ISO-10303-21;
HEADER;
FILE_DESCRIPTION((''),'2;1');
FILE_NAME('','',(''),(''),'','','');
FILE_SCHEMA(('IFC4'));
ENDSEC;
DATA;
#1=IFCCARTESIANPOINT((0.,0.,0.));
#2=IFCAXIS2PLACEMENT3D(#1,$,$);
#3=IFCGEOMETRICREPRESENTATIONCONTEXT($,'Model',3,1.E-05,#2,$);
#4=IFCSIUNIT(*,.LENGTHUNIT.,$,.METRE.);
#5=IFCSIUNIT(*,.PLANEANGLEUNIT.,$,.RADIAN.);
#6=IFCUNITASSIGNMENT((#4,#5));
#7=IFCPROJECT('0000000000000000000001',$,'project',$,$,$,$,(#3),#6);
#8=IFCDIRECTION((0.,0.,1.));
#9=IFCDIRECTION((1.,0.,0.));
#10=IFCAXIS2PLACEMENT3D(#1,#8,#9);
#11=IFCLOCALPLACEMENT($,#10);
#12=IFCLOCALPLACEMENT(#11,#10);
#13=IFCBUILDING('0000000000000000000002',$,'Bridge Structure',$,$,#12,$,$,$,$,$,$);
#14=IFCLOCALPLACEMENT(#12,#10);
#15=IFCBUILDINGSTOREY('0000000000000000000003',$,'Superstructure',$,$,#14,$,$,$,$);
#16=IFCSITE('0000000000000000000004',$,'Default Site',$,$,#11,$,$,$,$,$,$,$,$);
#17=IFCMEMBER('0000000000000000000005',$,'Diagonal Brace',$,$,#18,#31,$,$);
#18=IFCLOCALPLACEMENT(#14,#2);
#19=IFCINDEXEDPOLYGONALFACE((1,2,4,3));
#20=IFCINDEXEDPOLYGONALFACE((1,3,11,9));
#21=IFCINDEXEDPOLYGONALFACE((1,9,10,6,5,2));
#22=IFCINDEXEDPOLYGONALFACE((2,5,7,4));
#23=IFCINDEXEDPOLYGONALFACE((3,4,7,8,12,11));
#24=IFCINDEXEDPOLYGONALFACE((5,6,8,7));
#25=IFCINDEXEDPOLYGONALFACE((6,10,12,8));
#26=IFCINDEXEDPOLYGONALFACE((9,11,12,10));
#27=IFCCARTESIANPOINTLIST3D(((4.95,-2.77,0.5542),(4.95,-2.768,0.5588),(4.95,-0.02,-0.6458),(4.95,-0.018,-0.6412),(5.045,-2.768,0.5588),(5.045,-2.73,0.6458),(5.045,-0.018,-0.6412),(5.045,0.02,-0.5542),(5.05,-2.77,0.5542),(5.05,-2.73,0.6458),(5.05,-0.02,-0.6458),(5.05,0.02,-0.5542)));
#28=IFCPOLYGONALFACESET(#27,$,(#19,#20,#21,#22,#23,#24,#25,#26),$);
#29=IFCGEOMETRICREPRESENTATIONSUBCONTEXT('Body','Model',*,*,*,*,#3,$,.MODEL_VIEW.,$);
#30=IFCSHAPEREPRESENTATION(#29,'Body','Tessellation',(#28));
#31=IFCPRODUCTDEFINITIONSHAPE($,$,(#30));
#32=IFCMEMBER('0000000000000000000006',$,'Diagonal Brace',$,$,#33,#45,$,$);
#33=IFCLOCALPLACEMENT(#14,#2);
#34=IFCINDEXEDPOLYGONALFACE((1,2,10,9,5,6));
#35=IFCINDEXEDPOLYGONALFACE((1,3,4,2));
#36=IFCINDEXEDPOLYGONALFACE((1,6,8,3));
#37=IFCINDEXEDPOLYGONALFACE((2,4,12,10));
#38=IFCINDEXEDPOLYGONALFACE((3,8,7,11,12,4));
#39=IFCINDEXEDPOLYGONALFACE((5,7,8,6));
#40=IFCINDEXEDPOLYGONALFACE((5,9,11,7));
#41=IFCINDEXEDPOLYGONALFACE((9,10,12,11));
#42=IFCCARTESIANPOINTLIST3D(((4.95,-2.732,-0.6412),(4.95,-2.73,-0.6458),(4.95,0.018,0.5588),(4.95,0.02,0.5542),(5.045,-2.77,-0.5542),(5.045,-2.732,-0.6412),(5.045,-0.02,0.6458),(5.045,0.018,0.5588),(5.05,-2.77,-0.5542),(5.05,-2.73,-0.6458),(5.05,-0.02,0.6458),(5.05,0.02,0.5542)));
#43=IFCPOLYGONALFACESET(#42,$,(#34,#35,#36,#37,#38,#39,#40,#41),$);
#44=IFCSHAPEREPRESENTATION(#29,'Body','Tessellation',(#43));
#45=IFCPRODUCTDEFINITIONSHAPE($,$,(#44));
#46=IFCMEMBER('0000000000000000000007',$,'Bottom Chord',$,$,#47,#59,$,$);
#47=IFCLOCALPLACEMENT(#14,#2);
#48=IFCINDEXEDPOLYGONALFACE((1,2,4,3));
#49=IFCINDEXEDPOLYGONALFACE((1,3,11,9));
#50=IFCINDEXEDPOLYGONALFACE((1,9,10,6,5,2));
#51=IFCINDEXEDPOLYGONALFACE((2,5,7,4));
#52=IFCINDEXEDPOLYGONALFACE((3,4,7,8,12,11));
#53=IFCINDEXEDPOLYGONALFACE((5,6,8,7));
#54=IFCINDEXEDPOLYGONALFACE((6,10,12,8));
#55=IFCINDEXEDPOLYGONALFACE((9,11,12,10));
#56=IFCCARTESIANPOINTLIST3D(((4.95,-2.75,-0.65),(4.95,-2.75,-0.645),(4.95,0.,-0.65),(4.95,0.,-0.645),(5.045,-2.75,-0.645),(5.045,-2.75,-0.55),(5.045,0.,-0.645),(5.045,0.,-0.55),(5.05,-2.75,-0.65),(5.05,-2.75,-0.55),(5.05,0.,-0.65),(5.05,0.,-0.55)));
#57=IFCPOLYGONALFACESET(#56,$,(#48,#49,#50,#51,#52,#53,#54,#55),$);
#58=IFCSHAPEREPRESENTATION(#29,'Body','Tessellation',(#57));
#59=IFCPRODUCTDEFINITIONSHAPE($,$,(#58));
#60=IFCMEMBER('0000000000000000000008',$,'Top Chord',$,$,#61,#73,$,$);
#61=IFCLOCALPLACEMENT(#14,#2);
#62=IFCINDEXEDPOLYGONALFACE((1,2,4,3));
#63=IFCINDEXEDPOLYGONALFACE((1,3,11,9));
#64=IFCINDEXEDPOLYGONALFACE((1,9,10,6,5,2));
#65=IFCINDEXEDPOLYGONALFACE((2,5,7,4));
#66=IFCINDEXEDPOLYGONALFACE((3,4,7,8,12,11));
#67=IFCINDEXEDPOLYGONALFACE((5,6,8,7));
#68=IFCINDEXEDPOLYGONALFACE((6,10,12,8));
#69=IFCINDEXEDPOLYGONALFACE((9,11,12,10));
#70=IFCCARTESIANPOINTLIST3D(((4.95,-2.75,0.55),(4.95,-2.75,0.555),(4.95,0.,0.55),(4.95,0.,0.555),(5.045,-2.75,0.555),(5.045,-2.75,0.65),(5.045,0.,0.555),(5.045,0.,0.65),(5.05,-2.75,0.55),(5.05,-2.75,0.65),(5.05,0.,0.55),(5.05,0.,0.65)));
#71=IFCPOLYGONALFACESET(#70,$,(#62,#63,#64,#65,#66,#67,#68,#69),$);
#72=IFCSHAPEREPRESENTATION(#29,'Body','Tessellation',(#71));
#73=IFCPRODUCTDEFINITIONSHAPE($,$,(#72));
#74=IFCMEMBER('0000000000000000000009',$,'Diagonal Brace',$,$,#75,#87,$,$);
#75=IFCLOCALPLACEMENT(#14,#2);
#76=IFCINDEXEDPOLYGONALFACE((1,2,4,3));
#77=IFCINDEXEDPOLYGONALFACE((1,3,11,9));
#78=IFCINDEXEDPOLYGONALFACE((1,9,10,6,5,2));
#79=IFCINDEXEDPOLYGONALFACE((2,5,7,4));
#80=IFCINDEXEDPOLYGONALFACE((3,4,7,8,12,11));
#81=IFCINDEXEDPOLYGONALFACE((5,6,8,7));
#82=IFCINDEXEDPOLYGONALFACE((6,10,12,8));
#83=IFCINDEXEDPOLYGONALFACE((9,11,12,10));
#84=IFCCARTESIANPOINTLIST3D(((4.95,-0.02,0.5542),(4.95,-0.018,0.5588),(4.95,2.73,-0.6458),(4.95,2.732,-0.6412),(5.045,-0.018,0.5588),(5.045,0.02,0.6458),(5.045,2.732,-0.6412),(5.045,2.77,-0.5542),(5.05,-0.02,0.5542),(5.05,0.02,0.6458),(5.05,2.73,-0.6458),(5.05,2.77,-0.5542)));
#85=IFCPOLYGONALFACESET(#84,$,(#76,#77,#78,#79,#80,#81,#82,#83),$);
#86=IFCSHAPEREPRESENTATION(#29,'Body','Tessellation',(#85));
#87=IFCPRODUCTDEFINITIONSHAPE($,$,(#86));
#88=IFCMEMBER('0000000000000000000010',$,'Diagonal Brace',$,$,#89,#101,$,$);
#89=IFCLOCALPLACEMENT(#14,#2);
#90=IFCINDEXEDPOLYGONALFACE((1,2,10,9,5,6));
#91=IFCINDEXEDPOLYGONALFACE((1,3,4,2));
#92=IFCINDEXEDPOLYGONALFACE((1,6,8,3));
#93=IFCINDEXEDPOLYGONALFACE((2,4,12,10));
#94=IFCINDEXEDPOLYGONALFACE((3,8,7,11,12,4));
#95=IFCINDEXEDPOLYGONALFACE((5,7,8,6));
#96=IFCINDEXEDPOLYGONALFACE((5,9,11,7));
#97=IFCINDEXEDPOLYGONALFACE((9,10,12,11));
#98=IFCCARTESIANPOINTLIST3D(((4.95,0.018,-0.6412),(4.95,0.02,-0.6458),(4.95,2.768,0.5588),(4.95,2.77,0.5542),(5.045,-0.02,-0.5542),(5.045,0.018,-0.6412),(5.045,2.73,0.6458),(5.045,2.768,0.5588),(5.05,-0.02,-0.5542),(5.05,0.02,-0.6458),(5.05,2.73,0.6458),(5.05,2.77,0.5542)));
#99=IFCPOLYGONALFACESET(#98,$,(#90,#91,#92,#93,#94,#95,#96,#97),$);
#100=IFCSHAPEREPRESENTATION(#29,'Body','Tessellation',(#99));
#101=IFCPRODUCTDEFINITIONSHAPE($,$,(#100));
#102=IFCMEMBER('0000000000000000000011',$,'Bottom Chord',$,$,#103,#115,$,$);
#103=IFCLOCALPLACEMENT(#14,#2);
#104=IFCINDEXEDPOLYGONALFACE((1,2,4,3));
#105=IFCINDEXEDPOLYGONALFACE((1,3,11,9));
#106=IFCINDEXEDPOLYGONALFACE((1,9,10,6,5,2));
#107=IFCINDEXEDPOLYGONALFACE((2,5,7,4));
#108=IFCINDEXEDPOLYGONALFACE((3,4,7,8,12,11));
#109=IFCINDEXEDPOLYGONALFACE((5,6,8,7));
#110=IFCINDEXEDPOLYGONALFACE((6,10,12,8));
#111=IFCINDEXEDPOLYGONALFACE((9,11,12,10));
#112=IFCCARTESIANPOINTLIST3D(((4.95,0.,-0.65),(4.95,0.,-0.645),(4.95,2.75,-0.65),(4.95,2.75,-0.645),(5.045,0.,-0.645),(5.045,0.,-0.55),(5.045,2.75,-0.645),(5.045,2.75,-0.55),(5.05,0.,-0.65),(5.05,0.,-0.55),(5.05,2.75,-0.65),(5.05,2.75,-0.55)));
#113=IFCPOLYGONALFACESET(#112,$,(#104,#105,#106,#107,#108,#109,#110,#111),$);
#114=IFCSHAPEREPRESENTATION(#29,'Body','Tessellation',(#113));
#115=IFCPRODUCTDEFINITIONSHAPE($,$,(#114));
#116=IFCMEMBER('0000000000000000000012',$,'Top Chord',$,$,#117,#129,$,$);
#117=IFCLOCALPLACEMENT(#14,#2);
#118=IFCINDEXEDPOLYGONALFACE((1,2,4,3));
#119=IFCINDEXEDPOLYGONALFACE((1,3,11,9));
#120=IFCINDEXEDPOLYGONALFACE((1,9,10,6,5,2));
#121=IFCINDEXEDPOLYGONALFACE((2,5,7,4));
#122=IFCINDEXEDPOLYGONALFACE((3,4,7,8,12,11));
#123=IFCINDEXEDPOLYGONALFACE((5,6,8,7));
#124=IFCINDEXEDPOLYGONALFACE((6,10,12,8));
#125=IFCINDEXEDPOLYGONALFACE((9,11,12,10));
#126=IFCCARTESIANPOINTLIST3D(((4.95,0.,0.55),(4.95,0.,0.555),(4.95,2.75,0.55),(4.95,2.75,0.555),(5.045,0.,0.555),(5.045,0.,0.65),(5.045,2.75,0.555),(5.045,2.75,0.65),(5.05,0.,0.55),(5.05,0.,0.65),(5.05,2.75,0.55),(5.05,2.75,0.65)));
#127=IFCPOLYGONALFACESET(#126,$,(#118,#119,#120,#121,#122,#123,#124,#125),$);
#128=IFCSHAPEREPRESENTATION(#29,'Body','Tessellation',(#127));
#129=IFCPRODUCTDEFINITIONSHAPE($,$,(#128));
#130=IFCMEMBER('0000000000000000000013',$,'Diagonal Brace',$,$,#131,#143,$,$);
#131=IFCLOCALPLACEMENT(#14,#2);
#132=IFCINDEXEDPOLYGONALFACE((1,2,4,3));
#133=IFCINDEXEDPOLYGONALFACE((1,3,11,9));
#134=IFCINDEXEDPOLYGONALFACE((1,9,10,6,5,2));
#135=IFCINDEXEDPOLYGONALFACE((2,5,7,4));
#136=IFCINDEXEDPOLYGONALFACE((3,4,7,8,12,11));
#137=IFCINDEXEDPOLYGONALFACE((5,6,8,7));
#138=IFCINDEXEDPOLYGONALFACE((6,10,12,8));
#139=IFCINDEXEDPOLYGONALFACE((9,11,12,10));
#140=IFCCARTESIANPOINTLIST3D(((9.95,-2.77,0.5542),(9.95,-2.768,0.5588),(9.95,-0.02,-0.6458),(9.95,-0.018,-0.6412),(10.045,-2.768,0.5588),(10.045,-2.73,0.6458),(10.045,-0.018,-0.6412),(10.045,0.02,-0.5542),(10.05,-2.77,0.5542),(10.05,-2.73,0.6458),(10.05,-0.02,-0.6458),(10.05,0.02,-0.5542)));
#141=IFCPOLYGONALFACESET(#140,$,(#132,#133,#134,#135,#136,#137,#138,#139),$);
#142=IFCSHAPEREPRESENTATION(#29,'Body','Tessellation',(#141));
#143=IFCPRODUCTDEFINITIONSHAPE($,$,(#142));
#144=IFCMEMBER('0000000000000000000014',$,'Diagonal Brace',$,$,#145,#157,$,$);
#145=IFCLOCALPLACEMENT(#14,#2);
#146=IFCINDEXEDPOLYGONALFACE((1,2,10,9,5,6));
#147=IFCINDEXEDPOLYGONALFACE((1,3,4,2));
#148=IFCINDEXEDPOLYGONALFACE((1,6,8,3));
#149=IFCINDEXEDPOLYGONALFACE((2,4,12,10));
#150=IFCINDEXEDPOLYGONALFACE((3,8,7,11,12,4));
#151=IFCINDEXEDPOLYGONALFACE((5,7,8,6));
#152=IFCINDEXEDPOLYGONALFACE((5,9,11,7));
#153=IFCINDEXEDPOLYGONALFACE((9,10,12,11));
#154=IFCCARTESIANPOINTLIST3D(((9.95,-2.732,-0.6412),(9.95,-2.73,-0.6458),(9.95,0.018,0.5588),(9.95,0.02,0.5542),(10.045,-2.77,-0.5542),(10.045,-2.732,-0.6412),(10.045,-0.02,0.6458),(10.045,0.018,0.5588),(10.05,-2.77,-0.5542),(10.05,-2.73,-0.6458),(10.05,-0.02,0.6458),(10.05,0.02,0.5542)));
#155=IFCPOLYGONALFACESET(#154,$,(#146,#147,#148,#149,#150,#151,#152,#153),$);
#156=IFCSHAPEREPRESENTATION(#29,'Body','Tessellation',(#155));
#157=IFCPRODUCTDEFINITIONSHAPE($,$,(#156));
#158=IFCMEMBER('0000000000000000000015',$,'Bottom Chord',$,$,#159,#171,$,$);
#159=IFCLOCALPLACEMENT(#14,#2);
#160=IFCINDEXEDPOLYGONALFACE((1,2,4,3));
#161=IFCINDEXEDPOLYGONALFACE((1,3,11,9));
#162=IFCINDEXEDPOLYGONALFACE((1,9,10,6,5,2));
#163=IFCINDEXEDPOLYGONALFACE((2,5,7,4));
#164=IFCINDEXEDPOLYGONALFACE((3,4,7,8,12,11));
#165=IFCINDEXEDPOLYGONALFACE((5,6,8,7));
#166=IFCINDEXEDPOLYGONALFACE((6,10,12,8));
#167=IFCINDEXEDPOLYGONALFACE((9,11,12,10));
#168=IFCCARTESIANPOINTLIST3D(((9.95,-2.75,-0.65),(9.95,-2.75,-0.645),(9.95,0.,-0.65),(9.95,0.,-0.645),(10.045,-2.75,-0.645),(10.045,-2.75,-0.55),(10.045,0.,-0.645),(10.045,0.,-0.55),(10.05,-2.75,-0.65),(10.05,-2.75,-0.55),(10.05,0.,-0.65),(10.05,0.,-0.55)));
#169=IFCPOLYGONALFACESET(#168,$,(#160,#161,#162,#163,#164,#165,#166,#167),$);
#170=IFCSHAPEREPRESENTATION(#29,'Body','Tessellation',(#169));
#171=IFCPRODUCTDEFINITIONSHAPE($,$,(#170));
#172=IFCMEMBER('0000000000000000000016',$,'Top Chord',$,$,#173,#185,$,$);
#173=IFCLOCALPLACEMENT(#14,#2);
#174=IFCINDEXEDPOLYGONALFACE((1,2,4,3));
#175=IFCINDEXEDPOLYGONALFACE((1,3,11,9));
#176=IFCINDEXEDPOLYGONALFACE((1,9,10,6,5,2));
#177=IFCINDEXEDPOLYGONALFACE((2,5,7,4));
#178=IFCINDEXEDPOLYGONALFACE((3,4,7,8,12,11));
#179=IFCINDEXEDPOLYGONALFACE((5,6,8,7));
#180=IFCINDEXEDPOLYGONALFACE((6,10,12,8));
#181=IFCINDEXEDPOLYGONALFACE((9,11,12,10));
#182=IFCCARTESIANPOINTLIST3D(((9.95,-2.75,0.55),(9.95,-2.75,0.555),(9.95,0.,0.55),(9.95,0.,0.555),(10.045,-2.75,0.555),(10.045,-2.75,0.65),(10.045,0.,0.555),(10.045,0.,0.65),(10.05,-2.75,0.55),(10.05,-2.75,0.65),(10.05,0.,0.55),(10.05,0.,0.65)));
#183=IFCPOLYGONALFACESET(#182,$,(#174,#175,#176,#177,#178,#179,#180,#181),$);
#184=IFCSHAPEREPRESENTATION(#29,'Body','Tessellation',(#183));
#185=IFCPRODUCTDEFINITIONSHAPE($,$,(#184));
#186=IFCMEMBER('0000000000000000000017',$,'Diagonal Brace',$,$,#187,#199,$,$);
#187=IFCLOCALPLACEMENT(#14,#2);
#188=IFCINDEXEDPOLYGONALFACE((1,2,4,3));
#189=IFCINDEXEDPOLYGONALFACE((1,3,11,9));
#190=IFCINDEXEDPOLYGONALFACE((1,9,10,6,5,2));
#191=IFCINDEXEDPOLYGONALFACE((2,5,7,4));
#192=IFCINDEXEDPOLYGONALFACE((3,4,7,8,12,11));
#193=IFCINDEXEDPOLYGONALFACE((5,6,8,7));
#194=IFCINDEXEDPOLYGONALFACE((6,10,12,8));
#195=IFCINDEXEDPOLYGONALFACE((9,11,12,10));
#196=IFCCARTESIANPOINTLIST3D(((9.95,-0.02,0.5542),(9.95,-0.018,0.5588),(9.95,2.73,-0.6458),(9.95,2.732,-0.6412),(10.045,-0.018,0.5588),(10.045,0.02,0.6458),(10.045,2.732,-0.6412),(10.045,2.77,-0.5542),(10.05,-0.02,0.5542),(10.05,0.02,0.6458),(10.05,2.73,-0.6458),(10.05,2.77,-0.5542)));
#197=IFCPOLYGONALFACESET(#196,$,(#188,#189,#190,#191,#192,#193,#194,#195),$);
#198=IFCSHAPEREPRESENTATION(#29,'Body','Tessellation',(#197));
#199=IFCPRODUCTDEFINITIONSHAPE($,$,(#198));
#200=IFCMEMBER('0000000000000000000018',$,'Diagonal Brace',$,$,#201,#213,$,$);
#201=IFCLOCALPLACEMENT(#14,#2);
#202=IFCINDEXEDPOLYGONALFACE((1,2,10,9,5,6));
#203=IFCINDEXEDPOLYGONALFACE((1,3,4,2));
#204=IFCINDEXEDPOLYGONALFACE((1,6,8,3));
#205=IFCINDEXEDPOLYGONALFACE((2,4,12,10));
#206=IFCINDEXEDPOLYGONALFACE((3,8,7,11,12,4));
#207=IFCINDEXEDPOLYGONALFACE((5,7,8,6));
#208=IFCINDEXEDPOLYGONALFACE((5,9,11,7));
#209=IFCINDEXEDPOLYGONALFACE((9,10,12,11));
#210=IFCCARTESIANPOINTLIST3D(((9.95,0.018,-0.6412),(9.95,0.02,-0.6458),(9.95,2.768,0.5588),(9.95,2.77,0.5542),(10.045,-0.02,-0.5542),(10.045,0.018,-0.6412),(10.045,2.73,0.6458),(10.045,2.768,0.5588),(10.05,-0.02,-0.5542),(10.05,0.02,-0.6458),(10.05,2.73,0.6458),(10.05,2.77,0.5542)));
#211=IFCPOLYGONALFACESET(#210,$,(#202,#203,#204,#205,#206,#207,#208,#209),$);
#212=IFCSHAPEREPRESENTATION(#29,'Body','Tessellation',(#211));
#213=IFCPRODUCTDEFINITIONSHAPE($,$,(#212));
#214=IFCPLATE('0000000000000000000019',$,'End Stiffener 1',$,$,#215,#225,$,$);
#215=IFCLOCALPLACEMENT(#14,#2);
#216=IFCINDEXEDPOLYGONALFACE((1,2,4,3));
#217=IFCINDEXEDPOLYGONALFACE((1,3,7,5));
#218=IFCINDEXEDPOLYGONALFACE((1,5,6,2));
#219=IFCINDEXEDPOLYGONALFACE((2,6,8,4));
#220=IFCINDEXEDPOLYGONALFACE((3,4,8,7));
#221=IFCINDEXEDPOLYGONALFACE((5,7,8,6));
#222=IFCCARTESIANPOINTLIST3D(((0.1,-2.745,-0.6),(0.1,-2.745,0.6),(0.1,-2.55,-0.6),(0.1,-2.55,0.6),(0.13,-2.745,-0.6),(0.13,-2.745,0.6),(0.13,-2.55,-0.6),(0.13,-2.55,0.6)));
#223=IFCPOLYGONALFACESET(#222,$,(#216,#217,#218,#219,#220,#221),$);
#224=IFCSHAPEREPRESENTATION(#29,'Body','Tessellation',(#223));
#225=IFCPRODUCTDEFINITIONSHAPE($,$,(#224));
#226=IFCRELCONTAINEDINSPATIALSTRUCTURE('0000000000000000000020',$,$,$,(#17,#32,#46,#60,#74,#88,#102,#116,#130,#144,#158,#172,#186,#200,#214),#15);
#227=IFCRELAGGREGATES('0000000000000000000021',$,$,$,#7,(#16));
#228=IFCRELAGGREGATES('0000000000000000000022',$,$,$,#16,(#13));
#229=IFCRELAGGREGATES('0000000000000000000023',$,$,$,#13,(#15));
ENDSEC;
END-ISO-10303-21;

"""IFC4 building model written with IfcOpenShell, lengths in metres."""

from ifc_helpers import new_model, si_unit, frame, origin, origin_with_axes, origin_2d_with_axis, place, context, subcontext, project, spatial, rectangle, l_section, extrude, element, save


model = new_model("IFC4")

# Units and contexts
model_context = context("Model", 3, precision=1e-05, world=origin())
body_context = subcontext(model_context, "Body", "Model", "MODEL_VIEW")
ifc_project = project(units=[si_unit("LENGTHUNIT", "METRE"), si_unit("PLANEANGLEUNIT", "RADIAN")], contexts=[model_context])

# Site, building, storey
site_placement = place(None, origin_with_axes())
site = spatial("IfcSite", under=ifc_project, at=site_placement, Name="Default Site")
building_placement = place(site_placement, origin_with_axes())
building = spatial("IfcBuilding", under=site, at=building_placement, Name="Bridge Structure")
storey_placement = place(building_placement, origin_with_axes())
storey = spatial("IfcBuildingStorey", under=building, at=storey_placement, Name="Superstructure")

# Members
for number, where, z_axis, x_axis, name in (
    (1, (5.0, -2.75, 0.6), (0.0, 0.916539, -0.399944), (-1.0, 0.0, 0.0), "Diagonal Brace"),
    (2, (5.0, -2.75, -0.6), (0.0, 0.916539, 0.399944), (-1.0, 0.0, 0.0), "Diagonal Brace"),
):
    element("IfcMember", number, at=place(storey_placement, frame(where, z_axis=z_axis, x_axis=x_axis)), inside=storey, Name=name, context=body_context, shape_type="SweptSolid", body=[
        extrude(l_section(Depth=0.1, Width=0.1, Thickness=0.005, at=origin_2d_with_axis()), origin_with_axes(), (0.0, 0.0, 1.0), 3.0004),
    ])
for number, where, z_axis, x_axis, name in (
    (3, (5.0, -2.75, -0.6), (0.0, 1.0, 0.0), (-1.0, 0.0, 0.0), "Bottom Chord"),
    (4, (5.0, -2.75, 0.6), (0.0, 1.0, 0.0), (-1.0, 0.0, 0.0), "Top Chord"),
):
    element("IfcMember", number, at=place(storey_placement, frame(where, z_axis=z_axis, x_axis=x_axis)), inside=storey, Name=name, context=body_context, shape_type="SweptSolid", body=[
        extrude(l_section(Depth=0.1, Width=0.1, Thickness=0.005, at=origin_2d_with_axis()), origin_with_axes(), (0.0, 0.0, 1.0), 2.75),
    ])
for number, where, z_axis, x_axis, name in (
    (5, (5.0, 0.0, 0.6), (0.0, 0.916539, -0.399944), (-1.0, 0.0, 0.0), "Diagonal Brace"),
    (6, (5.0, 0.0, -0.6), (0.0, 0.916539, 0.399944), (-1.0, 0.0, 0.0), "Diagonal Brace"),
):
    element("IfcMember", number, at=place(storey_placement, frame(where, z_axis=z_axis, x_axis=x_axis)), inside=storey, Name=name, context=body_context, shape_type="SweptSolid", body=[
        extrude(l_section(Depth=0.1, Width=0.1, Thickness=0.005, at=origin_2d_with_axis()), origin_with_axes(), (0.0, 0.0, 1.0), 3.0004),
    ])
for number, where, z_axis, x_axis, name in (
    (7, (5.0, 0.0, -0.6), (0.0, 1.0, 0.0), (-1.0, 0.0, 0.0), "Bottom Chord"),
    (8, (5.0, 0.0, 0.6), (0.0, 1.0, 0.0), (-1.0, 0.0, 0.0), "Top Chord"),
):
    element("IfcMember", number, at=place(storey_placement, frame(where, z_axis=z_axis, x_axis=x_axis)), inside=storey, Name=name, context=body_context, shape_type="SweptSolid", body=[
        extrude(l_section(Depth=0.1, Width=0.1, Thickness=0.005, at=origin_2d_with_axis()), origin_with_axes(), (0.0, 0.0, 1.0), 2.75),
    ])
for number, where, z_axis, x_axis, name in (
    (9, (10.0, -2.75, 0.6), (0.0, 0.916539, -0.399944), (-1.0, 0.0, 0.0), "Diagonal Brace"),
    (10, (10.0, -2.75, -0.6), (0.0, 0.916539, 0.399944), (-1.0, 0.0, 0.0), "Diagonal Brace"),
):
    element("IfcMember", number, at=place(storey_placement, frame(where, z_axis=z_axis, x_axis=x_axis)), inside=storey, Name=name, context=body_context, shape_type="SweptSolid", body=[
        extrude(l_section(Depth=0.1, Width=0.1, Thickness=0.005, at=origin_2d_with_axis()), origin_with_axes(), (0.0, 0.0, 1.0), 3.0004),
    ])
for number, where, z_axis, x_axis, name in (
    (11, (10.0, -2.75, -0.6), (0.0, 1.0, 0.0), (-1.0, 0.0, 0.0), "Bottom Chord"),
    (12, (10.0, -2.75, 0.6), (0.0, 1.0, 0.0), (-1.0, 0.0, 0.0), "Top Chord"),
):
    element("IfcMember", number, at=place(storey_placement, frame(where, z_axis=z_axis, x_axis=x_axis)), inside=storey, Name=name, context=body_context, shape_type="SweptSolid", body=[
        extrude(l_section(Depth=0.1, Width=0.1, Thickness=0.005, at=origin_2d_with_axis()), origin_with_axes(), (0.0, 0.0, 1.0), 2.75),
    ])
for number, where, z_axis, x_axis, name in (
    (13, (10.0, 0.0, 0.6), (0.0, 0.916539, -0.399944), (-1.0, 0.0, 0.0), "Diagonal Brace"),
    (14, (10.0, 0.0, -0.6), (0.0, 0.916539, 0.399944), (-1.0, 0.0, 0.0), "Diagonal Brace"),
):
    element("IfcMember", number, at=place(storey_placement, frame(where, z_axis=z_axis, x_axis=x_axis)), inside=storey, Name=name, context=body_context, shape_type="SweptSolid", body=[
        extrude(l_section(Depth=0.1, Width=0.1, Thickness=0.005, at=origin_2d_with_axis()), origin_with_axes(), (0.0, 0.0, 1.0), 3.0004),
    ])

# Plate
for number, where, z_axis, x_axis, name in (
    (15, (0.115, -2.6475, -0.6), (0.0, 0.0, 1.0), (1.0, 0.0, 0.0), "End Stiffener 1"),
):
    element("IfcPlate", number, at=place(storey_placement, frame(where, z_axis=z_axis, x_axis=x_axis)), inside=storey, Name=name, context=body_context, shape_type="SweptSolid", body=[
        extrude(rectangle(XDim=0.03, YDim=0.195, at=origin_2d_with_axis()), origin_with_axes(), (0.0, 0.0, 1.0), 1.2),
    ])

save(model, "model.ifc")
